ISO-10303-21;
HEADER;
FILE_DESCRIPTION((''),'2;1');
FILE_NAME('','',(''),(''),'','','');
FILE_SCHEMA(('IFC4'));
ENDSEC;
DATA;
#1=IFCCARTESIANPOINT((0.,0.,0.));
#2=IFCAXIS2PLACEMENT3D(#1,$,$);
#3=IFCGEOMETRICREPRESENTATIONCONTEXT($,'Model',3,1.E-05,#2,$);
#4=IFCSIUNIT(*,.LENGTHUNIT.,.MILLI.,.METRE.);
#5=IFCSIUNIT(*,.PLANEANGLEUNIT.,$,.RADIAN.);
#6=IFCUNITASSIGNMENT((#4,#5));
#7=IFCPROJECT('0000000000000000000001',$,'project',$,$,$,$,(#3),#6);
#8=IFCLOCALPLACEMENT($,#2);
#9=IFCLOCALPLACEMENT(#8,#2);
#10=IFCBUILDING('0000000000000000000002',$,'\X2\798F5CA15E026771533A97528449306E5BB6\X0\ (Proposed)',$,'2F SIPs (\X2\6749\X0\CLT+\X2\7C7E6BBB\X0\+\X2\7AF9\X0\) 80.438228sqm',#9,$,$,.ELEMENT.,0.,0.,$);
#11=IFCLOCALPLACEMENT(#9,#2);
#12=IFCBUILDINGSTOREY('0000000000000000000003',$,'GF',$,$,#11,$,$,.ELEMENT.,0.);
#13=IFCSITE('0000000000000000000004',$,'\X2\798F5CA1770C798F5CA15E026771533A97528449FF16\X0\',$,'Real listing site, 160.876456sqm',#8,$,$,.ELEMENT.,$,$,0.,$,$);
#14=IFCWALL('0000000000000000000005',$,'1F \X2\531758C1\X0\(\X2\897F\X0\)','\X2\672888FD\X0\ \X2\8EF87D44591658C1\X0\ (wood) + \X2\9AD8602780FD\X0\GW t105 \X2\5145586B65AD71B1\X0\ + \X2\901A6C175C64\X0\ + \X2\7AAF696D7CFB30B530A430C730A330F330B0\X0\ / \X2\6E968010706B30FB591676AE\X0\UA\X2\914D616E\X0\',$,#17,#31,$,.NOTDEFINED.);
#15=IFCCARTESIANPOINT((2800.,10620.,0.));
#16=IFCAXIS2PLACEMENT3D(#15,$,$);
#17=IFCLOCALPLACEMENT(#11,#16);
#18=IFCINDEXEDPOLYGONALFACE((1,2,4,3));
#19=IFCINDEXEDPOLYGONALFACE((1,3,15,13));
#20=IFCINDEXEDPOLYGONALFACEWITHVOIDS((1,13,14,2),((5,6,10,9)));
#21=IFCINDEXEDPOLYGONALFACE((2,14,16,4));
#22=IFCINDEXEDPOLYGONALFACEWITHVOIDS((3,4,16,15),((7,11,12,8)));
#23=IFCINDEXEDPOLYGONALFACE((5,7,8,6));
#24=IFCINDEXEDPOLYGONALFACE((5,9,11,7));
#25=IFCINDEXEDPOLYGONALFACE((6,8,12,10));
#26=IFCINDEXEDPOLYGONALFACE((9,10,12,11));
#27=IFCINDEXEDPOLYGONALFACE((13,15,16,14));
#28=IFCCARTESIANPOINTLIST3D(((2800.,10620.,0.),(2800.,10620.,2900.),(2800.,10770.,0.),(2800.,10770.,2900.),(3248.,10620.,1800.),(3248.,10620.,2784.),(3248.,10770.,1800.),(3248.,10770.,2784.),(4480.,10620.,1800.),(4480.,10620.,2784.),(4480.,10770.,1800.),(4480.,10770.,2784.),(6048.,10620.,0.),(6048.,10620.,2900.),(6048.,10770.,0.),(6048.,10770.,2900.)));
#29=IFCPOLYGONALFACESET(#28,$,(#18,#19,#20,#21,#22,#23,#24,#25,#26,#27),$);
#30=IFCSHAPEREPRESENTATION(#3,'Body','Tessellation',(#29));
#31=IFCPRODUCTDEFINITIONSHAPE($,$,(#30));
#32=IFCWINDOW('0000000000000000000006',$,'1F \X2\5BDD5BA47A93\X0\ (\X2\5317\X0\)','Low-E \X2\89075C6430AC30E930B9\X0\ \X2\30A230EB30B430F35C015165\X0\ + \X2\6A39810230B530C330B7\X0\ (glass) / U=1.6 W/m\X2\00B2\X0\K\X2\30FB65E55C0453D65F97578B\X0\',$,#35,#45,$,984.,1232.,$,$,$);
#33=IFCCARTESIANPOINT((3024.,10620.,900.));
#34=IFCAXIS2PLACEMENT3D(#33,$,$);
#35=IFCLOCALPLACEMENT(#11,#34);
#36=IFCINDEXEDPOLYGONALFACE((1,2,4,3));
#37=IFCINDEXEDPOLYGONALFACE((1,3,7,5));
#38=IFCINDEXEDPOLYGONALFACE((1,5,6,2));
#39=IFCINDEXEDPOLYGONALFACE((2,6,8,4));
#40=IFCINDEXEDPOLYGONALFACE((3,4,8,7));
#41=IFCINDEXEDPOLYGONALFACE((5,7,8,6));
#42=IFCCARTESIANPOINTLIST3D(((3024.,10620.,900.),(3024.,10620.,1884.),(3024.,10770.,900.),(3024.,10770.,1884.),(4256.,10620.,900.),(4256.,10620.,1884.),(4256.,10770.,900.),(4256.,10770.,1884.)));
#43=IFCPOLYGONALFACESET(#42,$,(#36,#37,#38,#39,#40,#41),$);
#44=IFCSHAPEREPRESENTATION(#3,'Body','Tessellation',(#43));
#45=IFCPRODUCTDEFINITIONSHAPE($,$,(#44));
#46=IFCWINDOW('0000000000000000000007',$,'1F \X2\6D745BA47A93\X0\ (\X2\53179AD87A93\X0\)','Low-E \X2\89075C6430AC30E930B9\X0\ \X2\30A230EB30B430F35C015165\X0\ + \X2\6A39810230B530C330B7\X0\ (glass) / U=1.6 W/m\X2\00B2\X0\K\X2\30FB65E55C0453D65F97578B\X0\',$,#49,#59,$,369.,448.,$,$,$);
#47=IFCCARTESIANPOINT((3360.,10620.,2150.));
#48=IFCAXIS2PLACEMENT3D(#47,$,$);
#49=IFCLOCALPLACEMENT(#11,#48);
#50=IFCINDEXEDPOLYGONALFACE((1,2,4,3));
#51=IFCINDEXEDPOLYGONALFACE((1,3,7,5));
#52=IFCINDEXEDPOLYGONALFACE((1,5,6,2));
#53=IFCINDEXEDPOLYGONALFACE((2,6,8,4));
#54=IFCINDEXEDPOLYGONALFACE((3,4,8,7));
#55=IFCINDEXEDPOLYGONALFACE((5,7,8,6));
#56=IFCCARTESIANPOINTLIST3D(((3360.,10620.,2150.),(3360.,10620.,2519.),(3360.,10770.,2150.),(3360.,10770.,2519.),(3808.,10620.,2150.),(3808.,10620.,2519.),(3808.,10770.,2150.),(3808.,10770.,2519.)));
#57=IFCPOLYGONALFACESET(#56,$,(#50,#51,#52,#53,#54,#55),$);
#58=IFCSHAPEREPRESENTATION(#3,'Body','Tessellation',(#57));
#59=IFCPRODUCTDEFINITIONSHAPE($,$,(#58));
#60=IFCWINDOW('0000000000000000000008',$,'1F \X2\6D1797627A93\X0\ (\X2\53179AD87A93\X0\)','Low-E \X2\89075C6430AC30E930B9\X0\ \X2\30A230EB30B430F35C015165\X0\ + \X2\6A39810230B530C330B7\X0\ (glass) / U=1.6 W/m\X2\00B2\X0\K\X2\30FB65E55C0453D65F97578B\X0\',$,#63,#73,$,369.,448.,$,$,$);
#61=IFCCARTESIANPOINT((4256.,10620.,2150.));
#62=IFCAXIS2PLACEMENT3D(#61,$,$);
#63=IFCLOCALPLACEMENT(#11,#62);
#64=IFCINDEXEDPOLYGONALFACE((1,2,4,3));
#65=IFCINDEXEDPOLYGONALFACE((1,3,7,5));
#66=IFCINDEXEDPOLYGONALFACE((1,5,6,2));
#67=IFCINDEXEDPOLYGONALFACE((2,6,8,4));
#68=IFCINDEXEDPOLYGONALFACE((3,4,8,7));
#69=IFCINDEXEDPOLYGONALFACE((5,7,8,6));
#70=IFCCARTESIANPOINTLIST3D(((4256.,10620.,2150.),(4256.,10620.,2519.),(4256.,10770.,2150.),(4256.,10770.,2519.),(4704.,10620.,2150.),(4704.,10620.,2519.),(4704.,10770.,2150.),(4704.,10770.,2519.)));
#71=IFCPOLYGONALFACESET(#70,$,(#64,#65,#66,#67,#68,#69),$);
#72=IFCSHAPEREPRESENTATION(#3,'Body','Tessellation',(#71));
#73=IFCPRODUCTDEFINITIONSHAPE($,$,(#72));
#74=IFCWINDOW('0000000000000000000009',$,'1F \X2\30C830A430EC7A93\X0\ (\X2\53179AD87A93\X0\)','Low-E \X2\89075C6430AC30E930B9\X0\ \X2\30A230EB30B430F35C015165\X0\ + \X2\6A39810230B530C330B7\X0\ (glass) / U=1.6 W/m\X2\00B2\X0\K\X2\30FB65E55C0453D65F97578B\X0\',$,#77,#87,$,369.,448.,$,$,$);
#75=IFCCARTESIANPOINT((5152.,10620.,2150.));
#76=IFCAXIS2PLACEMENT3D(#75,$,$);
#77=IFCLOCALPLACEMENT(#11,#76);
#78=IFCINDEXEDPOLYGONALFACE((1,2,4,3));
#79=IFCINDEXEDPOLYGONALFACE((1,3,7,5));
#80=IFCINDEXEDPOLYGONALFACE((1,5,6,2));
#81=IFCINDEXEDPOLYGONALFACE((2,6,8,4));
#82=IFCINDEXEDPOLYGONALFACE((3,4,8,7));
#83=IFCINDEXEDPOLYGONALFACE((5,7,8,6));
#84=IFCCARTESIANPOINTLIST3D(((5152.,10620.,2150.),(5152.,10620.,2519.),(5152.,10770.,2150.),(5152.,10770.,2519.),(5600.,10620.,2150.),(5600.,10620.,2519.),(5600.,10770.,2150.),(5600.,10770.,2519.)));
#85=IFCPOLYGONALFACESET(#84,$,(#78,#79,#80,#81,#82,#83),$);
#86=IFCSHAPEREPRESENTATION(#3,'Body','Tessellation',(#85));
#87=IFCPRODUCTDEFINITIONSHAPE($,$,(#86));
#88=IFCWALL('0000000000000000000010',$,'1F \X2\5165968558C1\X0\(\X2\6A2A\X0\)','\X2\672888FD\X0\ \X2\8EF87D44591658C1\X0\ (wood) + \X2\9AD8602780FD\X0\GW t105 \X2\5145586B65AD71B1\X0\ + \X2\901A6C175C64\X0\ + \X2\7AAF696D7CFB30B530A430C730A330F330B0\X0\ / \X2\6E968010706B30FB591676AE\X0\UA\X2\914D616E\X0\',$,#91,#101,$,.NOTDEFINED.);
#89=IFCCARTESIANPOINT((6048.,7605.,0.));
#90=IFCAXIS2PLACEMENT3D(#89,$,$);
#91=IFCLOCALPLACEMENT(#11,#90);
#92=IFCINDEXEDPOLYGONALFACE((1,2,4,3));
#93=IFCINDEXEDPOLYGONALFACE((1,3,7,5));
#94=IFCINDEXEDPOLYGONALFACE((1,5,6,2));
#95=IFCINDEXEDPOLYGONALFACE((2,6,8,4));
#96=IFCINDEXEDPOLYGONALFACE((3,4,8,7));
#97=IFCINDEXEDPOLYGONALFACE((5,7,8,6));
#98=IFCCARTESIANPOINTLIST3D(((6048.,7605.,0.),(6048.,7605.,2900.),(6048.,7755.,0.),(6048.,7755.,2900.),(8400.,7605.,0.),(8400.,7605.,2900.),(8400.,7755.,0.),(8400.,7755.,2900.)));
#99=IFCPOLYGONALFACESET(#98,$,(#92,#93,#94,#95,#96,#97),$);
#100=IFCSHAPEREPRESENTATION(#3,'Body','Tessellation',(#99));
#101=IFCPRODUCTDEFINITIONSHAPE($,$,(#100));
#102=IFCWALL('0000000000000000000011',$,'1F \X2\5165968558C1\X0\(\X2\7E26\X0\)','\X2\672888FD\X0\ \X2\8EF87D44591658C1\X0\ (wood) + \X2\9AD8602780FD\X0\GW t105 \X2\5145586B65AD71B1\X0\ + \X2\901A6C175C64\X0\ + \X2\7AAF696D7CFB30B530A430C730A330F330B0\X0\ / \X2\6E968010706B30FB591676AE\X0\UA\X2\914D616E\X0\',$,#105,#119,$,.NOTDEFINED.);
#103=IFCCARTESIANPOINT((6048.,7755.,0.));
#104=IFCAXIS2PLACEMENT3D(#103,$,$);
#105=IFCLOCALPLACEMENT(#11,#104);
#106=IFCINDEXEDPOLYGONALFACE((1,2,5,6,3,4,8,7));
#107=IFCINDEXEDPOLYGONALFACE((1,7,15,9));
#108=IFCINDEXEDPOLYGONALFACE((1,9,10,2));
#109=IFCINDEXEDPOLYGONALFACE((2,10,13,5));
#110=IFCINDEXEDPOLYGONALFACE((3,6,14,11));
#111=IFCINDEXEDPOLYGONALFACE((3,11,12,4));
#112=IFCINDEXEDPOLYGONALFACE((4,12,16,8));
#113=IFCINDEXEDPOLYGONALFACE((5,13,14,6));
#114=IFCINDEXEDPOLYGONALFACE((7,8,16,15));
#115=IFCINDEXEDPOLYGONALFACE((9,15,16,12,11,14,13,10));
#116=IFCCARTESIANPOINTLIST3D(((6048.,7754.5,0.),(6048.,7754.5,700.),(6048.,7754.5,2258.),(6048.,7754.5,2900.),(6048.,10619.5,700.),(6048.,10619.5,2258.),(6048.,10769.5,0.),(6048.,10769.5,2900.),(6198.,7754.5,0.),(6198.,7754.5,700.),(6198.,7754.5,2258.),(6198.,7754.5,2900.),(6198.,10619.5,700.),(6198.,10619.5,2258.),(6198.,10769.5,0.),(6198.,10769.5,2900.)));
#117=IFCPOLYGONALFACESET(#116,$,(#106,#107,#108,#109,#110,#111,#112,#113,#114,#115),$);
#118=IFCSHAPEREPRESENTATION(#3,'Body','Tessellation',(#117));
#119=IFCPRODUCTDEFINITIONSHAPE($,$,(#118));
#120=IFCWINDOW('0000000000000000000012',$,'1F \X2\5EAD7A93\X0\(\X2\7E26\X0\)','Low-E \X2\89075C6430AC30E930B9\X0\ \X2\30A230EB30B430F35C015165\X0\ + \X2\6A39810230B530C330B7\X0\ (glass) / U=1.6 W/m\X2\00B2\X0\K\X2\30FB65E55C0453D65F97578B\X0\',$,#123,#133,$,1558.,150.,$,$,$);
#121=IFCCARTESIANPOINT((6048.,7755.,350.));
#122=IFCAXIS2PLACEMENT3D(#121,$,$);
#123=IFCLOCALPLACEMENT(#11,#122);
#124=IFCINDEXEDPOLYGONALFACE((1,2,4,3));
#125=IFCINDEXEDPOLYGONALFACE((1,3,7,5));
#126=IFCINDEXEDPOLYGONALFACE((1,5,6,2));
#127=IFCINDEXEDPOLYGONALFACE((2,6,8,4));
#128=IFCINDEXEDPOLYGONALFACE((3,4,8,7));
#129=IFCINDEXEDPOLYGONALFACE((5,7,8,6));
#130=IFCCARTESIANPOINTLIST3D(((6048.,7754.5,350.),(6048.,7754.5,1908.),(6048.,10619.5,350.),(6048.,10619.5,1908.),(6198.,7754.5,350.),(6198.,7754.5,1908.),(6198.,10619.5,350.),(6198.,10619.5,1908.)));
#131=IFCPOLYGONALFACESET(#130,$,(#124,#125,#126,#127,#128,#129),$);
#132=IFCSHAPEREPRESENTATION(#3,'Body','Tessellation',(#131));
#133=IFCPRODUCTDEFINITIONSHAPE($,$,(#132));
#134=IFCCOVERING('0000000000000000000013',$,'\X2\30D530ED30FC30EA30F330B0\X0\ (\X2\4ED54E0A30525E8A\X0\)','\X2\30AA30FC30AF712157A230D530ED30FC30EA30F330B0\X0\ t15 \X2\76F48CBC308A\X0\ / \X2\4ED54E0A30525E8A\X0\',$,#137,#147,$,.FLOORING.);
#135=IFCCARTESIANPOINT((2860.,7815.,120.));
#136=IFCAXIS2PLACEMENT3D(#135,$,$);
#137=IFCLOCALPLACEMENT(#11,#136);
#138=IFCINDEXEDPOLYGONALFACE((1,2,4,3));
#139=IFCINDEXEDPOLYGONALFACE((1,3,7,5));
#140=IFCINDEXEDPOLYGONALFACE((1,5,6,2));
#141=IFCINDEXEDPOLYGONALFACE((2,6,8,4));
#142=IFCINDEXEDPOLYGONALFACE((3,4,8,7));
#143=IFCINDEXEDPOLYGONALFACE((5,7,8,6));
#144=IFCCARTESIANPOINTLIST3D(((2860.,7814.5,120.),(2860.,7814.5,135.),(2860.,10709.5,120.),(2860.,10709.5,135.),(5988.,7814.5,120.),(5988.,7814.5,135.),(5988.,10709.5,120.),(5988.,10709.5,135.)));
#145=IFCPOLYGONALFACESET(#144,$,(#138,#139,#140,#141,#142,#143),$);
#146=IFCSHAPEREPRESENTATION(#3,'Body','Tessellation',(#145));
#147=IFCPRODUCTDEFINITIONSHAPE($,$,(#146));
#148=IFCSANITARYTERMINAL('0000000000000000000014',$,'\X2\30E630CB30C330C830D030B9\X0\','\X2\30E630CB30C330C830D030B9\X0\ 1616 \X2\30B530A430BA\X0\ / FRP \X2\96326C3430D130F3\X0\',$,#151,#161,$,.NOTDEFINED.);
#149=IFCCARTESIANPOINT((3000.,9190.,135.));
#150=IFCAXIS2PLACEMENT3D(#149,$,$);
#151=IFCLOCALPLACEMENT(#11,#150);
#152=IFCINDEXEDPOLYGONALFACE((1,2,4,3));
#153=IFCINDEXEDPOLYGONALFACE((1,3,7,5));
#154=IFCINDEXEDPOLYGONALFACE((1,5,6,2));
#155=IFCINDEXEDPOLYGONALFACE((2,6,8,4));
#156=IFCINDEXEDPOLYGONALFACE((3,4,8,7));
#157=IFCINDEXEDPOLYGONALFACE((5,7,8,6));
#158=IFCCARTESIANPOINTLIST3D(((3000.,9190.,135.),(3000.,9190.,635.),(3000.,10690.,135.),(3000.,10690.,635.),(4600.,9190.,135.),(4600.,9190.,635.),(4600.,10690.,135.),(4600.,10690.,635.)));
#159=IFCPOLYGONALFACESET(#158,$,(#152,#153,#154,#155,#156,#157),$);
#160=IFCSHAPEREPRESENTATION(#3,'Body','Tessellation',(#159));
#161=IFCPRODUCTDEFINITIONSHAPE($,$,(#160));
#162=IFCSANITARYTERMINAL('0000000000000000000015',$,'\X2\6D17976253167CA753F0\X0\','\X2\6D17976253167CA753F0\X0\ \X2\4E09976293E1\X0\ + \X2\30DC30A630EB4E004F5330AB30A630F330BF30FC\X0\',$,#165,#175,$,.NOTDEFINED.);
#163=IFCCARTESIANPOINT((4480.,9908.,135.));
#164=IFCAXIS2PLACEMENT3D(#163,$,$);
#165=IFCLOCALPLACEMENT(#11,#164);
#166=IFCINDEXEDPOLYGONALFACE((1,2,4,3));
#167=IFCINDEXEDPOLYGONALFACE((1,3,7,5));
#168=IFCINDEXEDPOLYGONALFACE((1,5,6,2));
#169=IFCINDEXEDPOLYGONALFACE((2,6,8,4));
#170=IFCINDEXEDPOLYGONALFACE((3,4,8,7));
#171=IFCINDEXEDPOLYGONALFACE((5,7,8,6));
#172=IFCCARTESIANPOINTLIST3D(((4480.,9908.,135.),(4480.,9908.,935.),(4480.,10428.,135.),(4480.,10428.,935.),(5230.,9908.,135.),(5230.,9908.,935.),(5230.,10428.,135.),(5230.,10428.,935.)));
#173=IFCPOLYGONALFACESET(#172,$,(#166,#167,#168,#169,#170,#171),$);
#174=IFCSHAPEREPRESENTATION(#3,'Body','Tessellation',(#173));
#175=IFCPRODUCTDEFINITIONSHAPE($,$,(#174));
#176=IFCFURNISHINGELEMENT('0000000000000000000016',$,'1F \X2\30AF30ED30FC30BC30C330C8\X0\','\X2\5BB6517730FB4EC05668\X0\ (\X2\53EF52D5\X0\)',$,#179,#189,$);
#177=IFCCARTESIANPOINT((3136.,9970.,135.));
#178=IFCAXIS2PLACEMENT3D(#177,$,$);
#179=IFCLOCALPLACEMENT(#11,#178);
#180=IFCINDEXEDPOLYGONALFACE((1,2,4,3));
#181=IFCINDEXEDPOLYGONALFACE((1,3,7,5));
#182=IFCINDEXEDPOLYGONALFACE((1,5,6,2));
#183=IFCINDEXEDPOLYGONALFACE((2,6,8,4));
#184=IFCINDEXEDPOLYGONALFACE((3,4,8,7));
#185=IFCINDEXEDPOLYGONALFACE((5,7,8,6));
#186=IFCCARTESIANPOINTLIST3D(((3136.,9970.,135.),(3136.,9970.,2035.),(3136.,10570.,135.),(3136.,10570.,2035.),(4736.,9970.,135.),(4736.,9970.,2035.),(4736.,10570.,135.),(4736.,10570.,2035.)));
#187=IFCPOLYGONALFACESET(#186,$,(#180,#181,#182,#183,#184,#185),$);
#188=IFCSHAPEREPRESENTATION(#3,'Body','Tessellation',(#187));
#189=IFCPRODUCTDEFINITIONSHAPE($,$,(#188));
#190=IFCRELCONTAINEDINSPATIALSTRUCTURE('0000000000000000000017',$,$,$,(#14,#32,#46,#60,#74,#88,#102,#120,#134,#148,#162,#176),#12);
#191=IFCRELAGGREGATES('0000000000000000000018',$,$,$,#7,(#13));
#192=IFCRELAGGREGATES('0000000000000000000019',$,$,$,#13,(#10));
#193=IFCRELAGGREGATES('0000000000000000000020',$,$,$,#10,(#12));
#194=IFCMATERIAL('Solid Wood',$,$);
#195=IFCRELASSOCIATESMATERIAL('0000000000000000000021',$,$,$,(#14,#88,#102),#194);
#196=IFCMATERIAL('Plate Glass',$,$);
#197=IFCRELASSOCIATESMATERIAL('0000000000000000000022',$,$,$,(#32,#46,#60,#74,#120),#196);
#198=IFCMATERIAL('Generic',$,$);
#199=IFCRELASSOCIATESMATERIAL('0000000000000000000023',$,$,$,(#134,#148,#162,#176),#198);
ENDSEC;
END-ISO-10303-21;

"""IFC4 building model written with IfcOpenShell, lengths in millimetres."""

from ifc_helpers import new_model, si_unit, frame, frame_2d, origin, place, context, project, spatial, rectangle, extrude, material, element, fill, save


model = new_model("IFC4")

# Units and contexts
model_context = context("Model", 3, precision=1e-05, world=origin())
ifc_project = project(units=[si_unit("LENGTHUNIT", "METRE", prefix="MILLI"), si_unit("PLANEANGLEUNIT", "RADIAN")], contexts=[model_context])

# Site, building, storey
site_placement = place(None, origin())
site = spatial("IfcSite", under=ifc_project, at=site_placement, Name="福岡県福岡市東区青葉６", ObjectType="Real listing site, 160.876456sqm", CompositionType="ELEMENT", RefElevation=0.0)
building_placement = place(site_placement, origin())
building = spatial("IfcBuilding", under=site, at=building_placement, Name="福岡市東区青葉の家 (Proposed)", ObjectType="2F SIPs (杉CLT+籾殻+竹) 80.438228sqm", CompositionType="ELEMENT", ElevationOfRefHeight=0.0, ElevationOfTerrain=0.0)
storey_placement = place(building_placement, origin())
storey = spatial("IfcBuildingStorey", under=building, at=storey_placement, Name="GF", CompositionType="ELEMENT", Elevation=0.0)

# Shared definitions
ifc_material_1 = material(Name="Solid Wood")

# Wall, openings, windows
wall_1_placement = place(storey_placement, frame((2800.0, 10620.0, 0.0)))
wall_1 = element("IfcWall", 1, at=wall_1_placement, inside=storey, material=ifc_material_1, Name="1F 北壁(西)", Description="木製 軸組外壁 (wood) + 高性能GW t105 充填断熱 + 通気層 + 窯業系サイディング / 準耐火・外皮UA配慮", PredefinedType="NOTDEFINED", context=model_context, shape_type="SweptSolid", body=[
    extrude(rectangle(XDim=3248.0, YDim=150.0, at=frame_2d((1624.0, 75.0))), frame((2800.0, 10620.0, 0.0)), (0.0, 0.0, 1.0), 2900.0),
])
opening_1_placement = place(storey_placement, frame((3024.0, 10620.0, 900.0)))
opening_1 = element("IfcOpeningElement", 2, at=opening_1_placement, cuts=wall_1, PredefinedType="NOTDEFINED", context=model_context, shape_type="SweptSolid", body=[
    extrude(rectangle(XDim=1232.0, YDim=150.0, at=frame_2d((616.0, 75.0))), frame((3024.0, 10620.0, 900.0)), (0.0, 0.0, 1.0), 984.0),
])
opening_2_placement = place(storey_placement, frame((3360.0, 10620.0, 2150.0)))
opening_2 = element("IfcOpeningElement", 3, at=opening_2_placement, cuts=wall_1, PredefinedType="NOTDEFINED", context=model_context, shape_type="SweptSolid", body=[
    extrude(rectangle(XDim=448.0, YDim=150.0, at=frame_2d((224.0, 75.0))), frame((3360.0, 10620.0, 2150.0)), (0.0, 0.0, 1.0), 369.0),
])
opening_3_placement = place(storey_placement, frame((4256.0, 10620.0, 2150.0)))
opening_3 = element("IfcOpeningElement", 4, at=opening_3_placement, cuts=wall_1, PredefinedType="NOTDEFINED", context=model_context, shape_type="SweptSolid", body=[
    extrude(rectangle(XDim=448.0, YDim=150.0, at=frame_2d((224.0, 75.0))), frame((4256.0, 10620.0, 2150.0)), (0.0, 0.0, 1.0), 369.0),
])
opening_4_placement = place(storey_placement, frame((5152.0, 10620.0, 2150.0)))
opening_4 = element("IfcOpeningElement", 5, at=opening_4_placement, cuts=wall_1, PredefinedType="NOTDEFINED", context=model_context, shape_type="SweptSolid", body=[
    extrude(rectangle(XDim=448.0, YDim=150.0, at=frame_2d((224.0, 75.0))), frame((5152.0, 10620.0, 2150.0)), (0.0, 0.0, 1.0), 369.0),
])
ifc_material_2 = material(Name="Plate Glass")
window_1_placement = place(storey_placement, frame((3024.0, 10620.0, 900.0)))
window_1 = element("IfcWindow", 6, at=window_1_placement, inside=storey, material=ifc_material_2, Name="1F 寝室窓 (北)", Description="Low-E 複層ガラス アルゴン封入 + 樹脂サッシ (glass) / U=1.6 W/m²K・日射取得型", OverallHeight=984.0, OverallWidth=1232.0, context=model_context, shape_type="SweptSolid", body=[
    extrude(rectangle(XDim=1232.0, YDim=150.0, at=frame_2d((616.0, 75.0))), frame((3024.0, 10620.0, 900.0)), (0.0, 0.0, 1.0), 984.0),
])
fill(opening_1, window_1)
window_2_placement = place(storey_placement, frame((3360.0, 10620.0, 2150.0)))
window_2 = element("IfcWindow", 7, at=window_2_placement, inside=storey, material=ifc_material_2, Name="1F 浴室窓 (北高窓)", Description="Low-E 複層ガラス アルゴン封入 + 樹脂サッシ (glass) / U=1.6 W/m²K・日射取得型", OverallHeight=369.0, OverallWidth=448.0, context=model_context, shape_type="SweptSolid", body=[
    extrude(rectangle(XDim=448.0, YDim=150.0, at=frame_2d((224.0, 75.0))), frame((3360.0, 10620.0, 2150.0)), (0.0, 0.0, 1.0), 369.0),
])
fill(opening_2, window_2)
window_3_placement = place(storey_placement, frame((4256.0, 10620.0, 2150.0)))
window_3 = element("IfcWindow", 8, at=window_3_placement, inside=storey, material=ifc_material_2, Name="1F 洗面窓 (北高窓)", Description="Low-E 複層ガラス アルゴン封入 + 樹脂サッシ (glass) / U=1.6 W/m²K・日射取得型", OverallHeight=369.0, OverallWidth=448.0, context=model_context, shape_type="SweptSolid", body=[
    extrude(rectangle(XDim=448.0, YDim=150.0, at=frame_2d((224.0, 75.0))), frame((4256.0, 10620.0, 2150.0)), (0.0, 0.0, 1.0), 369.0),
])
fill(opening_3, window_3)
window_4_placement = place(storey_placement, frame((5152.0, 10620.0, 2150.0)))
window_4 = element("IfcWindow", 9, at=window_4_placement, inside=storey, material=ifc_material_2, Name="1F トイレ窓 (北高窓)", Description="Low-E 複層ガラス アルゴン封入 + 樹脂サッシ (glass) / U=1.6 W/m²K・日射取得型", OverallHeight=369.0, OverallWidth=448.0, context=model_context, shape_type="SweptSolid", body=[
    extrude(rectangle(XDim=448.0, YDim=150.0, at=frame_2d((224.0, 75.0))), frame((5152.0, 10620.0, 2150.0)), (0.0, 0.0, 1.0), 369.0),
])
fill(opening_4, window_4)

# Wall
wall_2_placement = place(storey_placement, frame((6048.0, 7605.0, 0.0)))
element("IfcWall", 10, at=wall_2_placement, inside=storey, material=ifc_material_1, Name="1F 入隅壁(横)", Description="木製 軸組外壁 (wood) + 高性能GW t105 充填断熱 + 通気層 + 窯業系サイディング / 準耐火・外皮UA配慮", PredefinedType="NOTDEFINED", context=model_context, shape_type="SweptSolid", body=[
    extrude(rectangle(XDim=2352.0, YDim=150.0, at=frame_2d((1176.0, 75.0))), frame((6048.0, 7605.0, 0.0)), (0.0, 0.0, 1.0), 2900.0),
])

# Wall, opening, window
wall_3_placement = place(storey_placement, frame((6048.0, 7755.0, 0.0)))
wall_3 = element("IfcWall", 11, at=wall_3_placement, inside=storey, material=ifc_material_1, Name="1F 入隅壁(縦)", Description="木製 軸組外壁 (wood) + 高性能GW t105 充填断熱 + 通気層 + 窯業系サイディング / 準耐火・外皮UA配慮", PredefinedType="NOTDEFINED", context=model_context, shape_type="SweptSolid", body=[
    extrude(rectangle(XDim=150.0, YDim=3015.0, at=frame_2d((75.0, 1507.0))), frame((6048.0, 7755.0, 0.0)), (0.0, 0.0, 1.0), 2900.0),
])
opening_5_placement = place(storey_placement, frame((6048.0, 7755.0, 350.0)))
opening_5 = element("IfcOpeningElement", 12, at=opening_5_placement, cuts=wall_3, PredefinedType="NOTDEFINED", context=model_context, shape_type="SweptSolid", body=[
    extrude(rectangle(XDim=150.0, YDim=2865.0, at=frame_2d((75.0, 1432.0))), frame((6048.0, 7755.0, 350.0)), (0.0, 0.0, 1.0), 1558.0),
])
window_5_placement = place(storey_placement, frame((6048.0, 7755.0, 350.0)))
window_5 = element("IfcWindow", 13, at=window_5_placement, inside=storey, material=ifc_material_2, Name="1F 庭窓(縦)", Description="Low-E 複層ガラス アルゴン封入 + 樹脂サッシ (glass) / U=1.6 W/m²K・日射取得型", OverallHeight=1558.0, OverallWidth=150.0, context=model_context, shape_type="SweptSolid", body=[
    extrude(rectangle(XDim=150.0, YDim=2865.0, at=frame_2d((75.0, 1432.0))), frame((6048.0, 7755.0, 350.0)), (0.0, 0.0, 1.0), 1558.0),
])
fill(opening_5, window_5)

# Covering
ifc_material_3 = material(Name="Generic")
covering_placement = place(storey_placement, frame((2860.0, 7815.0, 120.0)))
element("IfcCovering", 14, at=covering_placement, inside=storey, material=ifc_material_3, Name="フローリング (仕上げ床)", Description="オーク無垢フローリング t15 直貼り / 仕上げ床", PredefinedType="FLOORING", context=model_context, shape_type="SweptSolid", body=[
    extrude(rectangle(XDim=3128.0, YDim=2895.0, at=frame_2d((1564.0, 1447.0))), frame((2860.0, 7815.0, 120.0)), (0.0, 0.0, 1.0), 15.0),
])

# Sanitary terminals
sanitary_terminal_1_placement = place(storey_placement, frame((3000.0, 9190.0, 135.0)))
element("IfcSanitaryTerminal", 15, at=sanitary_terminal_1_placement, inside=storey, material=ifc_material_3, Name="ユニットバス", Description="ユニットバス 1616 サイズ / FRP 防水パン", PredefinedType="NOTDEFINED", context=model_context, shape_type="SweptSolid", body=[
    extrude(rectangle(XDim=1600.0, YDim=1500.0, at=frame_2d((800.0, 750.0))), frame((3000.0, 9190.0, 135.0)), (0.0, 0.0, 1.0), 500.0),
])
sanitary_terminal_2_placement = place(storey_placement, frame((4480.0, 9908.0, 135.0)))
element("IfcSanitaryTerminal", 16, at=sanitary_terminal_2_placement, inside=storey, material=ifc_material_3, Name="洗面化粧台", Description="洗面化粧台 三面鏡 + ボウル一体カウンター", PredefinedType="NOTDEFINED", context=model_context, shape_type="SweptSolid", body=[
    extrude(rectangle(XDim=750.0, YDim=520.0, at=frame_2d((375.0, 260.0))), frame((4480.0, 9908.0, 135.0)), (0.0, 0.0, 1.0), 800.0),
])

# Furnishing element
furnishing_1_placement = place(storey_placement, frame((3136.0, 9970.0, 135.0)))
element("IfcFurnishingElement", 17, at=furnishing_1_placement, inside=storey, material=ifc_material_3, Name="1F クローゼット", Description="家具・什器 (可動)", context=model_context, shape_type="SweptSolid", body=[
    extrude(rectangle(XDim=1600.0, YDim=600.0, at=frame_2d((800.0, 300.0))), frame((3136.0, 9970.0, 135.0)), (0.0, 0.0, 1.0), 1900.0),
])

save(model, "model.ifc")
